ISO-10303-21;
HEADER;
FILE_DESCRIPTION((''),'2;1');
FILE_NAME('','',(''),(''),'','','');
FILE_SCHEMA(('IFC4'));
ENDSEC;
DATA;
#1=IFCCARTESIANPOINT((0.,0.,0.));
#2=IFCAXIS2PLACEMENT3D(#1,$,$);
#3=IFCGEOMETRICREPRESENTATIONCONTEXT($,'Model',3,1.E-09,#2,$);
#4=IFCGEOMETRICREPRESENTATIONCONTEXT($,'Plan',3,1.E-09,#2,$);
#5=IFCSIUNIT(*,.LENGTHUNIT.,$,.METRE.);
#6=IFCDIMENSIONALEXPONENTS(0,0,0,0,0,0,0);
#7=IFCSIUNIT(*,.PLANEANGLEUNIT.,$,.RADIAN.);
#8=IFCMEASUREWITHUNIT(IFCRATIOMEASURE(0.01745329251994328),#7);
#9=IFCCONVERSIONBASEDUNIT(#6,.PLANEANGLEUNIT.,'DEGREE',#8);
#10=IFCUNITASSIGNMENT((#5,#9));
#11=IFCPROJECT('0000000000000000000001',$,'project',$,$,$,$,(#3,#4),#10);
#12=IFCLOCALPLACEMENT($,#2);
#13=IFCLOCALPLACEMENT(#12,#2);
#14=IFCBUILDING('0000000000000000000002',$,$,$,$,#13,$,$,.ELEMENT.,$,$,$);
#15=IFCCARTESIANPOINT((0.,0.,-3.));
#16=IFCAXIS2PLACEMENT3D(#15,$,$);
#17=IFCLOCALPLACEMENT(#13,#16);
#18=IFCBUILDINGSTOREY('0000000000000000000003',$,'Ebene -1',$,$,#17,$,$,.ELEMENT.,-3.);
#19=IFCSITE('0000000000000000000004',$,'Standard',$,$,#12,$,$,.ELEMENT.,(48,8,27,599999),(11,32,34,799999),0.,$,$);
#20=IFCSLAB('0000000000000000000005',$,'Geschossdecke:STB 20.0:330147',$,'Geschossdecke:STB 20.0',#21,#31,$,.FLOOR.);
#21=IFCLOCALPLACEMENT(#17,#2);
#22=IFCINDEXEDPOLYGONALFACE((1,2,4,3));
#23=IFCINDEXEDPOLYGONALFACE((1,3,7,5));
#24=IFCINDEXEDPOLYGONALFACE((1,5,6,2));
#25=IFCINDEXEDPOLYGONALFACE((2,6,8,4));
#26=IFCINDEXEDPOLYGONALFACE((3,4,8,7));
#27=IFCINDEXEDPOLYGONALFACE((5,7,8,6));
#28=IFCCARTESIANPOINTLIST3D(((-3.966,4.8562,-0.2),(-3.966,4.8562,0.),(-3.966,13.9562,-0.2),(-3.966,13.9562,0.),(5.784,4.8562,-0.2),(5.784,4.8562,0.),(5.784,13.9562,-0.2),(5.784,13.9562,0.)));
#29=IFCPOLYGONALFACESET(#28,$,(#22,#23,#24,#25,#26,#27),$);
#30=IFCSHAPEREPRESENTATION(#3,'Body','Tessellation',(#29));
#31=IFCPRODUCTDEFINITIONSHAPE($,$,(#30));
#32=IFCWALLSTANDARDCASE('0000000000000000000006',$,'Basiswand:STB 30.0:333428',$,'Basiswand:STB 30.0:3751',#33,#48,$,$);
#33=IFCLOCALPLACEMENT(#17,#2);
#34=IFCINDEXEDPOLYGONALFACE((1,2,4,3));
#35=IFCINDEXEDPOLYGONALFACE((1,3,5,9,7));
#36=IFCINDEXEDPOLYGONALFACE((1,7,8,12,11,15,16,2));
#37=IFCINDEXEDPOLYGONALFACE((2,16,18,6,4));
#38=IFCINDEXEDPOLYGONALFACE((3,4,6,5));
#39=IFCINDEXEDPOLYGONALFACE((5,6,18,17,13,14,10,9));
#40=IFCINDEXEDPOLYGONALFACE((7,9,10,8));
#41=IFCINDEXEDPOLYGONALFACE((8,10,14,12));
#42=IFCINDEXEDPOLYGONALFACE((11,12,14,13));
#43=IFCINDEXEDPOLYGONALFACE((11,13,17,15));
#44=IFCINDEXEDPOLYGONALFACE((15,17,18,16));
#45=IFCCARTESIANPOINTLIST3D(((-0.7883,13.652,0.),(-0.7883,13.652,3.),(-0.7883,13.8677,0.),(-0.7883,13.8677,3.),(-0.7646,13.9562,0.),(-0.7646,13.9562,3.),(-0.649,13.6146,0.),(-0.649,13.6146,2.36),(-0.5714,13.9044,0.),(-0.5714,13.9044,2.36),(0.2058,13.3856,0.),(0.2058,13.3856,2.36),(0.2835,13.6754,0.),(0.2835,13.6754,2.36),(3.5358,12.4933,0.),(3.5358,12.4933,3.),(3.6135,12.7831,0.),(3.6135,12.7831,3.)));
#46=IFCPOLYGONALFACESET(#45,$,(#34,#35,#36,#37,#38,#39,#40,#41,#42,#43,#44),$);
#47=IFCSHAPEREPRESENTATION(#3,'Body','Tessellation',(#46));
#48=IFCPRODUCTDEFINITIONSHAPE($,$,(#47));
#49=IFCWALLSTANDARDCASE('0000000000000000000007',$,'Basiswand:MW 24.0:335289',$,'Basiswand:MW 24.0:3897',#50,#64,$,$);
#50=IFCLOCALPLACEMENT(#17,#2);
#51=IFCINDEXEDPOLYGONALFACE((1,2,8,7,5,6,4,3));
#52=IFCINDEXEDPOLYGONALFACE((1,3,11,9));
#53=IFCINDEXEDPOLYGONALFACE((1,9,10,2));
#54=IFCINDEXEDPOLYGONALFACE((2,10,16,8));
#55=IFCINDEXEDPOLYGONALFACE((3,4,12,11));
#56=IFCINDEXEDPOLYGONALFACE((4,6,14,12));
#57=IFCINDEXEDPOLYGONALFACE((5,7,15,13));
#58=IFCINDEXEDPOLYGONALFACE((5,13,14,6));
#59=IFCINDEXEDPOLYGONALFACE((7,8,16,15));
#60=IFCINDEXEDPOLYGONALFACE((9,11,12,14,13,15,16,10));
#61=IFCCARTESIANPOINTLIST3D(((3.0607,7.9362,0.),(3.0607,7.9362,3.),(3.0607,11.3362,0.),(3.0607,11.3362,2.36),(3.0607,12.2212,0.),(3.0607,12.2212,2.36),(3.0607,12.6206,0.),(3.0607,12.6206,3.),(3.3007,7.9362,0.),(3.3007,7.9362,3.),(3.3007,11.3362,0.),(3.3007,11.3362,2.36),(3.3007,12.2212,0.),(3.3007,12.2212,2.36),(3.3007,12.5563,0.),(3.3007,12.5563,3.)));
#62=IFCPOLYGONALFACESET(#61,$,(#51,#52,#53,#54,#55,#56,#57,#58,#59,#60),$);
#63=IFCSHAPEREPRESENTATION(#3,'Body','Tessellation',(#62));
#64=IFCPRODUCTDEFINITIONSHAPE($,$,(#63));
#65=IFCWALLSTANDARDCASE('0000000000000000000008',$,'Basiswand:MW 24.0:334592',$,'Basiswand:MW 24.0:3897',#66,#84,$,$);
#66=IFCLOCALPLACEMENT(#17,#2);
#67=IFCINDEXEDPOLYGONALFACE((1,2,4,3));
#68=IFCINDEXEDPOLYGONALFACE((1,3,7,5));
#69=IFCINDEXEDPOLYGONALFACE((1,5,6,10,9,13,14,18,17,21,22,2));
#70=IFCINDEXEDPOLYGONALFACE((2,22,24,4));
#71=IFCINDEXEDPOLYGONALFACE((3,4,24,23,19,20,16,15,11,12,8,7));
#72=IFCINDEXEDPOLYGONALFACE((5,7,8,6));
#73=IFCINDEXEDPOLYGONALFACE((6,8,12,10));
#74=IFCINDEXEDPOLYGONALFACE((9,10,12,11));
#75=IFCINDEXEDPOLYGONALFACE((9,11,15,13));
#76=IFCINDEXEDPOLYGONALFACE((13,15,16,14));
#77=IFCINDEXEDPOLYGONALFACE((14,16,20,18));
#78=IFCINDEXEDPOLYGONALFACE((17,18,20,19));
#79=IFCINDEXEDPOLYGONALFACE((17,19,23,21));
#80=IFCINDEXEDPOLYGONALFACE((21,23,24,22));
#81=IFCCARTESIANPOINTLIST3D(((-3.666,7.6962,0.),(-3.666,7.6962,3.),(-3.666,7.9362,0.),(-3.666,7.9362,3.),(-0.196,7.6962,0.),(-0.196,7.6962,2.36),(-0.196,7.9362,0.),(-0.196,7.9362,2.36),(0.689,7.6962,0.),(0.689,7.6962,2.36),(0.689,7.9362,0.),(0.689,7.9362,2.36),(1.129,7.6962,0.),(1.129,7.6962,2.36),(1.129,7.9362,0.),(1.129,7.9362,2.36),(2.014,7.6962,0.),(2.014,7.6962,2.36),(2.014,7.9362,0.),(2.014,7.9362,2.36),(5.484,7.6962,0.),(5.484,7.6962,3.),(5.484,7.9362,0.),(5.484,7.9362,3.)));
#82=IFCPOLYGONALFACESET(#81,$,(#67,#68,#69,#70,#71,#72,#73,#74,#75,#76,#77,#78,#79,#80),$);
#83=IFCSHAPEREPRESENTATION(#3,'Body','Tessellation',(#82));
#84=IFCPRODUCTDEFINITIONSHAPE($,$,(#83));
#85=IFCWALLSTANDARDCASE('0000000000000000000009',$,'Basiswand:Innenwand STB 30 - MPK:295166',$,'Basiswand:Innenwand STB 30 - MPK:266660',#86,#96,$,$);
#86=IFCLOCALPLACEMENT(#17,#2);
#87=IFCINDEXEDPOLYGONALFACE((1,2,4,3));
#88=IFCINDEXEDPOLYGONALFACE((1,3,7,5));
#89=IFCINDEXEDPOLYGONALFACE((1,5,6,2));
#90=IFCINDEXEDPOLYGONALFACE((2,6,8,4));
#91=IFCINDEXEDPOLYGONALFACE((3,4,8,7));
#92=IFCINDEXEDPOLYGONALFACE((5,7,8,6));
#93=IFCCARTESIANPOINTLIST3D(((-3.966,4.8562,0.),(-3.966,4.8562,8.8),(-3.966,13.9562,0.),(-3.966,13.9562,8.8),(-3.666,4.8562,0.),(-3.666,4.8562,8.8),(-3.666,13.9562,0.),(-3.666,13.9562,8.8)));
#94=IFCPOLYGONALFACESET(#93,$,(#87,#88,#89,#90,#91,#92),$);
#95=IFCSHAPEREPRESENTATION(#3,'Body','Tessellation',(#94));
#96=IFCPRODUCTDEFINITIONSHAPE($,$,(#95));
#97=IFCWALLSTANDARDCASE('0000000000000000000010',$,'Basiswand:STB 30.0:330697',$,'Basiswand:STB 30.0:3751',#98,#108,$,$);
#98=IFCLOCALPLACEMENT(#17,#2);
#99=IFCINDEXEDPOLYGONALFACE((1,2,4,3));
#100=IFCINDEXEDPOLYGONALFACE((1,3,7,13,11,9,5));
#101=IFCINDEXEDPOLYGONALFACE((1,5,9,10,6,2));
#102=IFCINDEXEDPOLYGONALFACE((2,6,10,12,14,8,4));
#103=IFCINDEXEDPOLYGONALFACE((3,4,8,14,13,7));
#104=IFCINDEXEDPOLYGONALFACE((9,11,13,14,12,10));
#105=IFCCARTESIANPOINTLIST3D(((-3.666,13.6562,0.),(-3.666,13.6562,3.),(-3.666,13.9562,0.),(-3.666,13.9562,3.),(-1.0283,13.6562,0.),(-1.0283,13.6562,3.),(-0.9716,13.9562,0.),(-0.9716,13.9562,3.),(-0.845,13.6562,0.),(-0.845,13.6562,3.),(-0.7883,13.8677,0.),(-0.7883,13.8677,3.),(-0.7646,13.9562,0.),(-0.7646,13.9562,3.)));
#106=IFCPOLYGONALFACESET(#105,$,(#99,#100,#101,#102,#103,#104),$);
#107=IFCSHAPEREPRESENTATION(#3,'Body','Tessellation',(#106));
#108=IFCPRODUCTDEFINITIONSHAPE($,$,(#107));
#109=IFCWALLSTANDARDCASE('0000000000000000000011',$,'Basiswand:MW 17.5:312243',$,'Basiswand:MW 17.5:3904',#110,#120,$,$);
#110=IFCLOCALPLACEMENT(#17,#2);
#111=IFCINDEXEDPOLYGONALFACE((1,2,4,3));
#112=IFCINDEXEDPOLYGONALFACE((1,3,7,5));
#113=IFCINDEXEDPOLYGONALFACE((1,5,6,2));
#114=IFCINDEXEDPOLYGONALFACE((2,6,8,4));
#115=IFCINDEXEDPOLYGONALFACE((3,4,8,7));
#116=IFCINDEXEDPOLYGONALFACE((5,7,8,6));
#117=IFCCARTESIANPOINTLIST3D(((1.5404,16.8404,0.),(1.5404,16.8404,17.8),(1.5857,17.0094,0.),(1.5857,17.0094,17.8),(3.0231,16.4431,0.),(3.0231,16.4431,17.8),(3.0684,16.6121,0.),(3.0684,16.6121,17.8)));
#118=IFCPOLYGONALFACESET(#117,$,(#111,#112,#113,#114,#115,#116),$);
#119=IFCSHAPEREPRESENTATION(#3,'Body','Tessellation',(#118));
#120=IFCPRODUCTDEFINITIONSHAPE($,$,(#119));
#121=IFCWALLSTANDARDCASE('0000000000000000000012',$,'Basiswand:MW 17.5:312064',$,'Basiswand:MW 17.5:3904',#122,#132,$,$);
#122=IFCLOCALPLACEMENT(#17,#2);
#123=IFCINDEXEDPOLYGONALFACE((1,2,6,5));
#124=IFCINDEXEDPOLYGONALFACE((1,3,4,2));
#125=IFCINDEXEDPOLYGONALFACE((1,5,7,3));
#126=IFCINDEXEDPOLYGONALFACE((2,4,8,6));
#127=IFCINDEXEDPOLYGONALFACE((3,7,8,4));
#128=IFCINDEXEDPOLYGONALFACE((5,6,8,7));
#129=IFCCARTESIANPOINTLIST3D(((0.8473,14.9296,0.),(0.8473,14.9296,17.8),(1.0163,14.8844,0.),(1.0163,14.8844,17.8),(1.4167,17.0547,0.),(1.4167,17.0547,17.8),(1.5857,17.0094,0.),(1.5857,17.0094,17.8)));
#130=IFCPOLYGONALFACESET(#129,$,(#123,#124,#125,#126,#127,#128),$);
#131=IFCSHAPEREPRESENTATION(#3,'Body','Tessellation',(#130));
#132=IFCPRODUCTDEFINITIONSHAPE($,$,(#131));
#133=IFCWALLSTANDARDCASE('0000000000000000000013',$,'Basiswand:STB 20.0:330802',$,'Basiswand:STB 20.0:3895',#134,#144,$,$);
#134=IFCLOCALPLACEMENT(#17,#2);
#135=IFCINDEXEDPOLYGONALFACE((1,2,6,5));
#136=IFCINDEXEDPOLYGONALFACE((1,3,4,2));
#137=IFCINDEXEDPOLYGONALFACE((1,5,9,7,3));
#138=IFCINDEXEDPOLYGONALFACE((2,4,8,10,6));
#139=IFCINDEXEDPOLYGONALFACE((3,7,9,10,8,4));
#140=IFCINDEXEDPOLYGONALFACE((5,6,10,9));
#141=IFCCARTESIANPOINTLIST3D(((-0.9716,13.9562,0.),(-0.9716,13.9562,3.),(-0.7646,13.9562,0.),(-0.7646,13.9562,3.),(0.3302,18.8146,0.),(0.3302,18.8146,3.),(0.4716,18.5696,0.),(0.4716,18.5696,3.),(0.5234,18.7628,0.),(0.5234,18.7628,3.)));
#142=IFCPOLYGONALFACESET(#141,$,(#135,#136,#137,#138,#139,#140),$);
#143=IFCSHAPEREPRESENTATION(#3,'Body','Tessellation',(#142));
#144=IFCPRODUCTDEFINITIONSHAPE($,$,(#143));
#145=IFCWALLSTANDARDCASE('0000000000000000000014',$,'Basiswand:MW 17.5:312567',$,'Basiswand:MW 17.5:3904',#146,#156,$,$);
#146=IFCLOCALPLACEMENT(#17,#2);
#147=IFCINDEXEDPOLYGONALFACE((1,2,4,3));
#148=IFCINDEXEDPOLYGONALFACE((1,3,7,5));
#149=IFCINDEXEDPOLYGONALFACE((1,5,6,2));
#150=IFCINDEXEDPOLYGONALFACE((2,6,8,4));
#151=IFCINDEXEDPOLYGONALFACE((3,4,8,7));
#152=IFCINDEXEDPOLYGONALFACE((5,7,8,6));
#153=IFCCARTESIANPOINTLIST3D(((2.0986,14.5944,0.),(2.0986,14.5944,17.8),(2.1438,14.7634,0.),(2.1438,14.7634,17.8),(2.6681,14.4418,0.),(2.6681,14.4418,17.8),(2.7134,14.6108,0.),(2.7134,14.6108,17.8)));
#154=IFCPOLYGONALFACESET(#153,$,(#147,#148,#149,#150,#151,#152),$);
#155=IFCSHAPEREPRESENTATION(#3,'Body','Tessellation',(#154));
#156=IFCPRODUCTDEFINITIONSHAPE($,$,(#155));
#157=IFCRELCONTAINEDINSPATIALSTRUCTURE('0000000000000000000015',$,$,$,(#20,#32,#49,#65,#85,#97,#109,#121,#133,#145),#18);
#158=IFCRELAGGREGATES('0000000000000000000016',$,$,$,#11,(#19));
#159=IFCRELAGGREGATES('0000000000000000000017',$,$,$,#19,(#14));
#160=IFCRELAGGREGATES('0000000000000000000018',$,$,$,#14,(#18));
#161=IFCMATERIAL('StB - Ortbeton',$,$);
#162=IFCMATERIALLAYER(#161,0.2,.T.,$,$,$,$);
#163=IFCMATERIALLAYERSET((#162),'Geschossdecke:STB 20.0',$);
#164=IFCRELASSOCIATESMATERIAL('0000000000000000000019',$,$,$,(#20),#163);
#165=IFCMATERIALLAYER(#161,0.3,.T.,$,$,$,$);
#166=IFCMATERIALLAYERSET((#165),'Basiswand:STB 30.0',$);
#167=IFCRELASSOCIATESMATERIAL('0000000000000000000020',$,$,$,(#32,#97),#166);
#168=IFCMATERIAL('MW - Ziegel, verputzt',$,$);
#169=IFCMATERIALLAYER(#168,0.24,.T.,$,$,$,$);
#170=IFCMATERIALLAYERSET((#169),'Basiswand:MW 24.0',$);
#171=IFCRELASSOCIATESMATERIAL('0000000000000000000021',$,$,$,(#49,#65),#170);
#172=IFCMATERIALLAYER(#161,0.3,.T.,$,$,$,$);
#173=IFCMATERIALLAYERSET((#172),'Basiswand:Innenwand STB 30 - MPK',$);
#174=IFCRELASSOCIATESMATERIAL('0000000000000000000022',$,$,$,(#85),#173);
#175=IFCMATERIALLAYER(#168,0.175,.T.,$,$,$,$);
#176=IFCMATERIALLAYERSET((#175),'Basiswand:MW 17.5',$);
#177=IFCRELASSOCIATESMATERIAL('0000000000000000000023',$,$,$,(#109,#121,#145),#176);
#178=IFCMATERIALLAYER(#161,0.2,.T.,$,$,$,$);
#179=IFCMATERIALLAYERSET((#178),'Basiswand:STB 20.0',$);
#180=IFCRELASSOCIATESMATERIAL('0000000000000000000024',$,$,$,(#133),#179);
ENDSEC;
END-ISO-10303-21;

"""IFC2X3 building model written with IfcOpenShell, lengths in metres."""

from ifc_helpers import new_model, entity, si_unit, converted_unit, frame, frame_2d, origin, place, context, project, spatial, polyline, rectangle, outline, extrude, clip, bounded_halfspace, material, layer, layer_set, layer_usage, element, save


model = new_model("IFC2X3")

# Units and contexts
model_context = context("Model", 3, precision=1e-09, world=origin())
plan_context = context("Plan", 3, precision=1e-09, world=origin())
ifc_project = project(units=[si_unit("LENGTHUNIT", "METRE"), converted_unit("PLANEANGLEUNIT", "DEGREE", entity("IfcRatioMeasure", 0.01745329251994328), si_unit("PLANEANGLEUNIT", "RADIAN"), dimensions=[0, 0, 0, 0, 0, 0, 0])], contexts=[model_context, plan_context])

# Site, building, storey
site_placement = place(None, origin())
site = spatial("IfcSite", under=ifc_project, at=site_placement, Name="Standard", CompositionType="ELEMENT", RefLatitude=(48, 8, 27, 599999), RefLongitude=(11, 32, 34, 799999), RefElevation=0.0)
building_placement = place(site_placement, origin())
building = spatial("IfcBuilding", under=site, at=building_placement, CompositionType="ELEMENT")
storey_placement = place(building_placement, frame((0.0, 0.0, -3.0)))
storey = spatial("IfcBuildingStorey", under=building, at=storey_placement, Name="Ebene -1", CompositionType="ELEMENT", Elevation=-3.0)

# Slab
ifc_material_1 = material(Name="StB - Ortbeton")
ifc_layer_1 = layer(ifc_material_1, 0.2, ventilated=True)
ifc_layer_set_1 = layer_set([ifc_layer_1], Name="Geschossdecke:STB 20.0")
ifc_layer_usage_1 = layer_usage(ifc_layer_set_1, "AXIS3", "POSITIVE", 0.0)
slab_1_placement = place(storey_placement, frame((-3.966, 4.8562, -0.2)))
element("IfcSlab", 1, at=slab_1_placement, inside=storey, material=ifc_layer_usage_1, Name="Geschossdecke:STB 20.0:330147", ObjectType="Geschossdecke:STB 20.0", PredefinedType="FLOOR", context=model_context, shape_type="SweptSolid", body=[
    extrude(rectangle(XDim=9.1, YDim=9.75, at=frame_2d((0.0, 0.0), x_axis=(0.0, -1.0))), frame((4.875, 4.55, 0.2), z_axis=(0.0, 0.0, -1.0), x_axis=(-1.0, 0.0, 0.0)), (0.0, 0.0, 1.0), 0.2),
])

# Walls, openings
ifc_layer_2 = layer(ifc_material_1, 0.3, ventilated=True)
ifc_layer_set_2 = layer_set([ifc_layer_2], Name="Basiswand:STB 30.0")
ifc_layer_usage_2 = layer_usage(ifc_layer_set_2, "AXIS2", "NEGATIVE", 0.15)
wall_1_placement = place(storey_placement, frame((-0.8034, 13.8113, 0.0), z_axis=(0.0, 0.0, 1.0), x_axis=(0.965926, -0.258819, 0.0)))
wall_1 = element("IfcWallStandardCase", 2, at=wall_1_placement, inside=storey, material=ifc_layer_usage_2, Name="Basiswand:STB 30.0:333428", ObjectType="Basiswand:STB 30.0:3751", context=model_context, shape_type="SweptSolid", body=[
    extrude(outline(polyline([(0.0558, -0.15), (4.0406, -0.15), (4.2891, -0.15), (4.5325, -0.15), (4.5325, 0.15), (0.0, 0.15), (0.0, 0.0584), (0.0558, -0.15)])), origin(), (0.0, 0.0, 1.0), 3.0),
])
opening_1_placement = place(wall_1_placement, frame((0.2, -0.15, 0.0)))
element("IfcOpeningElement", 3, at=opening_1_placement, cuts=wall_1, ObjectType="Opening", context=model_context, shape_type="SweptSolid", body=[
    extrude(rectangle(XDim=2.36, YDim=0.885, at=frame_2d((1.18, 0.4425), x_axis=(1.0, 0.0))), frame((0.0, 0.0, 0.0), z_axis=(0.0, 1.0, 0.0), x_axis=(0.0, 0.0, 1.0)), (0.0, 0.0, 1.0), 0.3),
])
ifc_material_2 = material(Name="MW - Ziegel, verputzt")
ifc_layer_3 = layer(ifc_material_2, 0.24, ventilated=True)
ifc_layer_set_3 = layer_set([ifc_layer_3], Name="Basiswand:MW 24.0")
ifc_layer_usage_3 = layer_usage(ifc_layer_set_3, "AXIS2", "NEGATIVE", 0.12)
wall_2_placement = place(storey_placement, frame((3.1807, 7.9362, 0.0), z_axis=(0.0, 0.0, 1.0), x_axis=(0.0, 1.0, 0.0)))
wall_2 = element("IfcWallStandardCase", 4, at=wall_2_placement, inside=storey, material=ifc_layer_usage_3, Name="Basiswand:MW 24.0:335289", ObjectType="Basiswand:MW 24.0:3897", context=model_context, shape_type="SweptSolid", body=[
    extrude(outline(polyline([(0.0, -0.12), (4.6201, -0.12), (4.6844, 0.12), (0.0, 0.12), (0.0, -0.12)])), origin(), (0.0, 0.0, 1.0), 3.0),
])
opening_2_placement = place(wall_2_placement, frame((3.4, -0.12, 0.0)))
element("IfcOpeningElement", 5, at=opening_2_placement, cuts=wall_2, ObjectType="Opening", context=model_context, shape_type="SweptSolid", body=[
    extrude(rectangle(XDim=2.36, YDim=0.885, at=frame_2d((1.18, 0.4425), x_axis=(1.0, 0.0))), frame((0.0, 0.0, 0.0), z_axis=(0.0, 1.0, 0.0), x_axis=(0.0, 0.0, 1.0)), (0.0, 0.0, 1.0), 0.24),
])

# Wall, openings
ifc_layer_usage_4 = layer_usage(ifc_layer_set_3, "AXIS2", "NEGATIVE", 0.12)
wall_3_placement = place(storey_placement, frame((-3.666, 7.8162, 0.0)))
wall_3 = element("IfcWallStandardCase", 6, at=wall_3_placement, inside=storey, material=ifc_layer_usage_4, Name="Basiswand:MW 24.0:334592", ObjectType="Basiswand:MW 24.0:3897", context=model_context, shape_type="SweptSolid", body=[
    extrude(rectangle(XDim=9.15, YDim=0.24, at=frame_2d((4.575, 0.0), x_axis=(-1.0, 0.0))), origin(), (0.0, 0.0, 1.0), 3.0),
])
opening_3_placement = place(wall_3_placement, frame((4.795, -0.12, 0.0)))
element("IfcOpeningElement", 7, at=opening_3_placement, cuts=wall_3, ObjectType="Opening", context=model_context, shape_type="SweptSolid", body=[
    extrude(rectangle(XDim=2.36, YDim=0.885, at=frame_2d((1.18, 0.4425), x_axis=(1.0, 0.0))), frame((0.0, 0.0, 0.0), z_axis=(0.0, 1.0, 0.0), x_axis=(0.0, 0.0, 1.0)), (0.0, 0.0, 1.0), 0.24),
])
opening_4_placement = place(wall_3_placement, frame((3.47, -0.12, 0.0)))
element("IfcOpeningElement", 8, at=opening_4_placement, cuts=wall_3, ObjectType="Opening", context=model_context, shape_type="SweptSolid", body=[
    extrude(rectangle(XDim=2.36, YDim=0.885, at=frame_2d((1.18, 0.4425), x_axis=(1.0, 0.0))), frame((0.0, 0.0, 0.0), z_axis=(0.0, 1.0, 0.0), x_axis=(0.0, 0.0, 1.0)), (0.0, 0.0, 1.0), 0.24),
])

# Walls
ifc_layer_4 = layer(ifc_material_1, 0.3, ventilated=True)
ifc_layer_set_4 = layer_set([ifc_layer_4], Name="Basiswand:Innenwand STB 30 - MPK")
ifc_layer_usage_5 = layer_usage(ifc_layer_set_4, "AXIS2", "NEGATIVE", 0.15)
wall_4_placement = place(storey_placement, frame((-3.816, 13.9562, 0.0), z_axis=(0.0, 0.0, 1.0), x_axis=(0.0, -1.0, 0.0)))
element("IfcWallStandardCase", 9, at=wall_4_placement, inside=storey, material=ifc_layer_usage_5, Name="Basiswand:Innenwand STB 30 - MPK:295166", ObjectType="Basiswand:Innenwand STB 30 - MPK:266660", context=model_context, shape_type="Clipping", body=[
    clip(extrude(rectangle(XDim=9.1, YDim=0.3, at=frame_2d((4.55, 0.0), x_axis=(-1.0, 0.0))), origin(), (0.0, 0.0, 1.0), 8.8), bounded_halfspace(frame((0.0, -0.15, 8.8), z_axis=(0.0, 0.0, -1.0), x_axis=(1.0, 0.0, 0.0)), True, frame((0.0, -0.15, 8.8)), polyline([(0.0, 0.0), (9.1, 0.0), (9.1, 0.3), (0.0, 0.3), (0.0, 0.0)]))),
])
ifc_layer_usage_6 = layer_usage(ifc_layer_set_2, "AXIS2", "NEGATIVE", 0.15)
wall_5_placement = place(storey_placement, frame((-3.666, 13.8062, 0.0)))
element("IfcWallStandardCase", 10, at=wall_5_placement, inside=storey, material=ifc_layer_usage_6, Name="Basiswand:STB 30.0:330697", ObjectType="Basiswand:STB 30.0:3751", context=model_context, shape_type="SweptSolid", body=[
    extrude(outline(polyline([(2.821, -0.15), (2.8777, 0.0615), (2.9014, 0.15), (2.6944, 0.15), (0.0, 0.15), (0.0, -0.15), (2.6377, -0.15), (2.821, -0.15)])), origin(), (0.0, 0.0, 1.0), 3.0),
])
ifc_layer_5 = layer(ifc_material_2, 0.175, ventilated=True)
ifc_layer_set_5 = layer_set([ifc_layer_5], Name="Basiswand:MW 17.5")
ifc_layer_usage_7 = layer_usage(ifc_layer_set_5, "AXIS2", "NEGATIVE", 0.0875)
wall_6_placement = place(storey_placement, frame((3.0458, 16.5276, 0.0), z_axis=(0.0, 0.0, 1.0), x_axis=(-0.965926, 0.258819, 0.0)))
element("IfcWallStandardCase", 11, at=wall_6_placement, inside=storey, material=ifc_layer_usage_7, Name="Basiswand:MW 17.5:312243", ObjectType="Basiswand:MW 17.5:3904", context=model_context, shape_type="Clipping", body=[
    clip(extrude(rectangle(XDim=1.535, YDim=0.175, at=frame_2d((0.7675, 0.0), x_axis=(-1.0, 0.0))), origin(), (0.0, 0.0, 1.0), 17.8), bounded_halfspace(frame((0.0, -0.0875, 17.8), z_axis=(0.0, 0.0, -1.0), x_axis=(-1.0, 0.0, 0.0)), True, frame((0.0, -0.0875, 17.8)), polyline([(0.0, 0.0), (1.535, 0.0), (1.535, 0.175), (0.0, 0.175), (0.0, 0.0)]))),
])
ifc_layer_usage_8 = layer_usage(ifc_layer_set_5, "AXIS2", "NEGATIVE", 0.0875)
wall_7_placement = place(storey_placement, frame((1.5012, 17.032, 0.0), z_axis=(0.0, 0.0, 1.0), x_axis=(-0.258819, -0.965926, 0.0)))
element("IfcWallStandardCase", 12, at=wall_7_placement, inside=storey, material=ifc_layer_usage_8, Name="Basiswand:MW 17.5:312064", ObjectType="Basiswand:MW 17.5:3904", context=model_context, shape_type="Clipping", body=[
    clip(extrude(rectangle(XDim=2.2, YDim=0.175, at=frame_2d((1.1, 0.0), x_axis=(-1.0, 0.0))), origin(), (0.0, 0.0, 1.0), 17.8), bounded_halfspace(frame((0.0, -0.0875, 17.8), z_axis=(0.0, 0.0, -1.0), x_axis=(0.0, 1.0, 0.0)), True, frame((0.0, -0.0875, 17.8)), polyline([(0.0, 0.0), (2.2, 0.0), (2.2, 0.175), (2.025, 0.175), (0.175, 0.175), (0.0, 0.175), (0.0, 0.0)]))),
])
ifc_layer_6 = layer(ifc_material_1, 0.2, ventilated=True)
ifc_layer_set_6 = layer_set([ifc_layer_6], Name="Basiswand:STB 20.0")
ifc_layer_usage_9 = layer_usage(ifc_layer_set_6, "AXIS2", "NEGATIVE", 0.1)
wall_8_placement = place(storey_placement, frame((-0.875, 13.9303, 0.0), z_axis=(0.0, 0.0, 1.0), x_axis=(0.258819, 0.965926, 0.0)))
element("IfcWallStandardCase", 13, at=wall_8_placement, inside=storey, material=ifc_layer_usage_9, Name="Basiswand:STB 20.0:330802", ObjectType="Basiswand:STB 20.0:3895", context=model_context, shape_type="SweptSolid", body=[
    extrude(outline(polyline([(5.0298, -0.1), (5.0298, 0.1), (0.0, 0.1), (0.0536, -0.1), (4.8298, -0.1), (5.0298, -0.1)])), origin(), (0.0, 0.0, 1.0), 3.0),
])
ifc_layer_usage_10 = layer_usage(ifc_layer_set_5, "AXIS2", "NEGATIVE", 0.0875)
wall_9_placement = place(storey_placement, frame((2.1212, 14.6789, 0.0), z_axis=(0.0, 0.0, 1.0), x_axis=(0.965926, -0.258819, 0.0)))
element("IfcWallStandardCase", 14, at=wall_9_placement, inside=storey, material=ifc_layer_usage_10, Name="Basiswand:MW 17.5:312567", ObjectType="Basiswand:MW 17.5:3904", context=model_context, shape_type="Clipping", body=[
    clip(extrude(rectangle(XDim=0.5896, YDim=0.175, at=frame_2d((0.2948, 0.0), x_axis=(-1.0, 0.0))), origin(), (0.0, 0.0, 1.0), 17.8), bounded_halfspace(frame((0.0, -0.0875, 17.8), z_axis=(0.0, 0.0, -1.0), x_axis=(1.0, 0.0, 0.0)), True, frame((0.0, -0.0875, 17.8)), polyline([(0.0, 0.0), (0.5896, 0.0), (0.5896, 0.175), (0.4146, 0.175), (0.0, 0.175), (0.0, 0.0)]))),
])

save(model, "model.ifc")
